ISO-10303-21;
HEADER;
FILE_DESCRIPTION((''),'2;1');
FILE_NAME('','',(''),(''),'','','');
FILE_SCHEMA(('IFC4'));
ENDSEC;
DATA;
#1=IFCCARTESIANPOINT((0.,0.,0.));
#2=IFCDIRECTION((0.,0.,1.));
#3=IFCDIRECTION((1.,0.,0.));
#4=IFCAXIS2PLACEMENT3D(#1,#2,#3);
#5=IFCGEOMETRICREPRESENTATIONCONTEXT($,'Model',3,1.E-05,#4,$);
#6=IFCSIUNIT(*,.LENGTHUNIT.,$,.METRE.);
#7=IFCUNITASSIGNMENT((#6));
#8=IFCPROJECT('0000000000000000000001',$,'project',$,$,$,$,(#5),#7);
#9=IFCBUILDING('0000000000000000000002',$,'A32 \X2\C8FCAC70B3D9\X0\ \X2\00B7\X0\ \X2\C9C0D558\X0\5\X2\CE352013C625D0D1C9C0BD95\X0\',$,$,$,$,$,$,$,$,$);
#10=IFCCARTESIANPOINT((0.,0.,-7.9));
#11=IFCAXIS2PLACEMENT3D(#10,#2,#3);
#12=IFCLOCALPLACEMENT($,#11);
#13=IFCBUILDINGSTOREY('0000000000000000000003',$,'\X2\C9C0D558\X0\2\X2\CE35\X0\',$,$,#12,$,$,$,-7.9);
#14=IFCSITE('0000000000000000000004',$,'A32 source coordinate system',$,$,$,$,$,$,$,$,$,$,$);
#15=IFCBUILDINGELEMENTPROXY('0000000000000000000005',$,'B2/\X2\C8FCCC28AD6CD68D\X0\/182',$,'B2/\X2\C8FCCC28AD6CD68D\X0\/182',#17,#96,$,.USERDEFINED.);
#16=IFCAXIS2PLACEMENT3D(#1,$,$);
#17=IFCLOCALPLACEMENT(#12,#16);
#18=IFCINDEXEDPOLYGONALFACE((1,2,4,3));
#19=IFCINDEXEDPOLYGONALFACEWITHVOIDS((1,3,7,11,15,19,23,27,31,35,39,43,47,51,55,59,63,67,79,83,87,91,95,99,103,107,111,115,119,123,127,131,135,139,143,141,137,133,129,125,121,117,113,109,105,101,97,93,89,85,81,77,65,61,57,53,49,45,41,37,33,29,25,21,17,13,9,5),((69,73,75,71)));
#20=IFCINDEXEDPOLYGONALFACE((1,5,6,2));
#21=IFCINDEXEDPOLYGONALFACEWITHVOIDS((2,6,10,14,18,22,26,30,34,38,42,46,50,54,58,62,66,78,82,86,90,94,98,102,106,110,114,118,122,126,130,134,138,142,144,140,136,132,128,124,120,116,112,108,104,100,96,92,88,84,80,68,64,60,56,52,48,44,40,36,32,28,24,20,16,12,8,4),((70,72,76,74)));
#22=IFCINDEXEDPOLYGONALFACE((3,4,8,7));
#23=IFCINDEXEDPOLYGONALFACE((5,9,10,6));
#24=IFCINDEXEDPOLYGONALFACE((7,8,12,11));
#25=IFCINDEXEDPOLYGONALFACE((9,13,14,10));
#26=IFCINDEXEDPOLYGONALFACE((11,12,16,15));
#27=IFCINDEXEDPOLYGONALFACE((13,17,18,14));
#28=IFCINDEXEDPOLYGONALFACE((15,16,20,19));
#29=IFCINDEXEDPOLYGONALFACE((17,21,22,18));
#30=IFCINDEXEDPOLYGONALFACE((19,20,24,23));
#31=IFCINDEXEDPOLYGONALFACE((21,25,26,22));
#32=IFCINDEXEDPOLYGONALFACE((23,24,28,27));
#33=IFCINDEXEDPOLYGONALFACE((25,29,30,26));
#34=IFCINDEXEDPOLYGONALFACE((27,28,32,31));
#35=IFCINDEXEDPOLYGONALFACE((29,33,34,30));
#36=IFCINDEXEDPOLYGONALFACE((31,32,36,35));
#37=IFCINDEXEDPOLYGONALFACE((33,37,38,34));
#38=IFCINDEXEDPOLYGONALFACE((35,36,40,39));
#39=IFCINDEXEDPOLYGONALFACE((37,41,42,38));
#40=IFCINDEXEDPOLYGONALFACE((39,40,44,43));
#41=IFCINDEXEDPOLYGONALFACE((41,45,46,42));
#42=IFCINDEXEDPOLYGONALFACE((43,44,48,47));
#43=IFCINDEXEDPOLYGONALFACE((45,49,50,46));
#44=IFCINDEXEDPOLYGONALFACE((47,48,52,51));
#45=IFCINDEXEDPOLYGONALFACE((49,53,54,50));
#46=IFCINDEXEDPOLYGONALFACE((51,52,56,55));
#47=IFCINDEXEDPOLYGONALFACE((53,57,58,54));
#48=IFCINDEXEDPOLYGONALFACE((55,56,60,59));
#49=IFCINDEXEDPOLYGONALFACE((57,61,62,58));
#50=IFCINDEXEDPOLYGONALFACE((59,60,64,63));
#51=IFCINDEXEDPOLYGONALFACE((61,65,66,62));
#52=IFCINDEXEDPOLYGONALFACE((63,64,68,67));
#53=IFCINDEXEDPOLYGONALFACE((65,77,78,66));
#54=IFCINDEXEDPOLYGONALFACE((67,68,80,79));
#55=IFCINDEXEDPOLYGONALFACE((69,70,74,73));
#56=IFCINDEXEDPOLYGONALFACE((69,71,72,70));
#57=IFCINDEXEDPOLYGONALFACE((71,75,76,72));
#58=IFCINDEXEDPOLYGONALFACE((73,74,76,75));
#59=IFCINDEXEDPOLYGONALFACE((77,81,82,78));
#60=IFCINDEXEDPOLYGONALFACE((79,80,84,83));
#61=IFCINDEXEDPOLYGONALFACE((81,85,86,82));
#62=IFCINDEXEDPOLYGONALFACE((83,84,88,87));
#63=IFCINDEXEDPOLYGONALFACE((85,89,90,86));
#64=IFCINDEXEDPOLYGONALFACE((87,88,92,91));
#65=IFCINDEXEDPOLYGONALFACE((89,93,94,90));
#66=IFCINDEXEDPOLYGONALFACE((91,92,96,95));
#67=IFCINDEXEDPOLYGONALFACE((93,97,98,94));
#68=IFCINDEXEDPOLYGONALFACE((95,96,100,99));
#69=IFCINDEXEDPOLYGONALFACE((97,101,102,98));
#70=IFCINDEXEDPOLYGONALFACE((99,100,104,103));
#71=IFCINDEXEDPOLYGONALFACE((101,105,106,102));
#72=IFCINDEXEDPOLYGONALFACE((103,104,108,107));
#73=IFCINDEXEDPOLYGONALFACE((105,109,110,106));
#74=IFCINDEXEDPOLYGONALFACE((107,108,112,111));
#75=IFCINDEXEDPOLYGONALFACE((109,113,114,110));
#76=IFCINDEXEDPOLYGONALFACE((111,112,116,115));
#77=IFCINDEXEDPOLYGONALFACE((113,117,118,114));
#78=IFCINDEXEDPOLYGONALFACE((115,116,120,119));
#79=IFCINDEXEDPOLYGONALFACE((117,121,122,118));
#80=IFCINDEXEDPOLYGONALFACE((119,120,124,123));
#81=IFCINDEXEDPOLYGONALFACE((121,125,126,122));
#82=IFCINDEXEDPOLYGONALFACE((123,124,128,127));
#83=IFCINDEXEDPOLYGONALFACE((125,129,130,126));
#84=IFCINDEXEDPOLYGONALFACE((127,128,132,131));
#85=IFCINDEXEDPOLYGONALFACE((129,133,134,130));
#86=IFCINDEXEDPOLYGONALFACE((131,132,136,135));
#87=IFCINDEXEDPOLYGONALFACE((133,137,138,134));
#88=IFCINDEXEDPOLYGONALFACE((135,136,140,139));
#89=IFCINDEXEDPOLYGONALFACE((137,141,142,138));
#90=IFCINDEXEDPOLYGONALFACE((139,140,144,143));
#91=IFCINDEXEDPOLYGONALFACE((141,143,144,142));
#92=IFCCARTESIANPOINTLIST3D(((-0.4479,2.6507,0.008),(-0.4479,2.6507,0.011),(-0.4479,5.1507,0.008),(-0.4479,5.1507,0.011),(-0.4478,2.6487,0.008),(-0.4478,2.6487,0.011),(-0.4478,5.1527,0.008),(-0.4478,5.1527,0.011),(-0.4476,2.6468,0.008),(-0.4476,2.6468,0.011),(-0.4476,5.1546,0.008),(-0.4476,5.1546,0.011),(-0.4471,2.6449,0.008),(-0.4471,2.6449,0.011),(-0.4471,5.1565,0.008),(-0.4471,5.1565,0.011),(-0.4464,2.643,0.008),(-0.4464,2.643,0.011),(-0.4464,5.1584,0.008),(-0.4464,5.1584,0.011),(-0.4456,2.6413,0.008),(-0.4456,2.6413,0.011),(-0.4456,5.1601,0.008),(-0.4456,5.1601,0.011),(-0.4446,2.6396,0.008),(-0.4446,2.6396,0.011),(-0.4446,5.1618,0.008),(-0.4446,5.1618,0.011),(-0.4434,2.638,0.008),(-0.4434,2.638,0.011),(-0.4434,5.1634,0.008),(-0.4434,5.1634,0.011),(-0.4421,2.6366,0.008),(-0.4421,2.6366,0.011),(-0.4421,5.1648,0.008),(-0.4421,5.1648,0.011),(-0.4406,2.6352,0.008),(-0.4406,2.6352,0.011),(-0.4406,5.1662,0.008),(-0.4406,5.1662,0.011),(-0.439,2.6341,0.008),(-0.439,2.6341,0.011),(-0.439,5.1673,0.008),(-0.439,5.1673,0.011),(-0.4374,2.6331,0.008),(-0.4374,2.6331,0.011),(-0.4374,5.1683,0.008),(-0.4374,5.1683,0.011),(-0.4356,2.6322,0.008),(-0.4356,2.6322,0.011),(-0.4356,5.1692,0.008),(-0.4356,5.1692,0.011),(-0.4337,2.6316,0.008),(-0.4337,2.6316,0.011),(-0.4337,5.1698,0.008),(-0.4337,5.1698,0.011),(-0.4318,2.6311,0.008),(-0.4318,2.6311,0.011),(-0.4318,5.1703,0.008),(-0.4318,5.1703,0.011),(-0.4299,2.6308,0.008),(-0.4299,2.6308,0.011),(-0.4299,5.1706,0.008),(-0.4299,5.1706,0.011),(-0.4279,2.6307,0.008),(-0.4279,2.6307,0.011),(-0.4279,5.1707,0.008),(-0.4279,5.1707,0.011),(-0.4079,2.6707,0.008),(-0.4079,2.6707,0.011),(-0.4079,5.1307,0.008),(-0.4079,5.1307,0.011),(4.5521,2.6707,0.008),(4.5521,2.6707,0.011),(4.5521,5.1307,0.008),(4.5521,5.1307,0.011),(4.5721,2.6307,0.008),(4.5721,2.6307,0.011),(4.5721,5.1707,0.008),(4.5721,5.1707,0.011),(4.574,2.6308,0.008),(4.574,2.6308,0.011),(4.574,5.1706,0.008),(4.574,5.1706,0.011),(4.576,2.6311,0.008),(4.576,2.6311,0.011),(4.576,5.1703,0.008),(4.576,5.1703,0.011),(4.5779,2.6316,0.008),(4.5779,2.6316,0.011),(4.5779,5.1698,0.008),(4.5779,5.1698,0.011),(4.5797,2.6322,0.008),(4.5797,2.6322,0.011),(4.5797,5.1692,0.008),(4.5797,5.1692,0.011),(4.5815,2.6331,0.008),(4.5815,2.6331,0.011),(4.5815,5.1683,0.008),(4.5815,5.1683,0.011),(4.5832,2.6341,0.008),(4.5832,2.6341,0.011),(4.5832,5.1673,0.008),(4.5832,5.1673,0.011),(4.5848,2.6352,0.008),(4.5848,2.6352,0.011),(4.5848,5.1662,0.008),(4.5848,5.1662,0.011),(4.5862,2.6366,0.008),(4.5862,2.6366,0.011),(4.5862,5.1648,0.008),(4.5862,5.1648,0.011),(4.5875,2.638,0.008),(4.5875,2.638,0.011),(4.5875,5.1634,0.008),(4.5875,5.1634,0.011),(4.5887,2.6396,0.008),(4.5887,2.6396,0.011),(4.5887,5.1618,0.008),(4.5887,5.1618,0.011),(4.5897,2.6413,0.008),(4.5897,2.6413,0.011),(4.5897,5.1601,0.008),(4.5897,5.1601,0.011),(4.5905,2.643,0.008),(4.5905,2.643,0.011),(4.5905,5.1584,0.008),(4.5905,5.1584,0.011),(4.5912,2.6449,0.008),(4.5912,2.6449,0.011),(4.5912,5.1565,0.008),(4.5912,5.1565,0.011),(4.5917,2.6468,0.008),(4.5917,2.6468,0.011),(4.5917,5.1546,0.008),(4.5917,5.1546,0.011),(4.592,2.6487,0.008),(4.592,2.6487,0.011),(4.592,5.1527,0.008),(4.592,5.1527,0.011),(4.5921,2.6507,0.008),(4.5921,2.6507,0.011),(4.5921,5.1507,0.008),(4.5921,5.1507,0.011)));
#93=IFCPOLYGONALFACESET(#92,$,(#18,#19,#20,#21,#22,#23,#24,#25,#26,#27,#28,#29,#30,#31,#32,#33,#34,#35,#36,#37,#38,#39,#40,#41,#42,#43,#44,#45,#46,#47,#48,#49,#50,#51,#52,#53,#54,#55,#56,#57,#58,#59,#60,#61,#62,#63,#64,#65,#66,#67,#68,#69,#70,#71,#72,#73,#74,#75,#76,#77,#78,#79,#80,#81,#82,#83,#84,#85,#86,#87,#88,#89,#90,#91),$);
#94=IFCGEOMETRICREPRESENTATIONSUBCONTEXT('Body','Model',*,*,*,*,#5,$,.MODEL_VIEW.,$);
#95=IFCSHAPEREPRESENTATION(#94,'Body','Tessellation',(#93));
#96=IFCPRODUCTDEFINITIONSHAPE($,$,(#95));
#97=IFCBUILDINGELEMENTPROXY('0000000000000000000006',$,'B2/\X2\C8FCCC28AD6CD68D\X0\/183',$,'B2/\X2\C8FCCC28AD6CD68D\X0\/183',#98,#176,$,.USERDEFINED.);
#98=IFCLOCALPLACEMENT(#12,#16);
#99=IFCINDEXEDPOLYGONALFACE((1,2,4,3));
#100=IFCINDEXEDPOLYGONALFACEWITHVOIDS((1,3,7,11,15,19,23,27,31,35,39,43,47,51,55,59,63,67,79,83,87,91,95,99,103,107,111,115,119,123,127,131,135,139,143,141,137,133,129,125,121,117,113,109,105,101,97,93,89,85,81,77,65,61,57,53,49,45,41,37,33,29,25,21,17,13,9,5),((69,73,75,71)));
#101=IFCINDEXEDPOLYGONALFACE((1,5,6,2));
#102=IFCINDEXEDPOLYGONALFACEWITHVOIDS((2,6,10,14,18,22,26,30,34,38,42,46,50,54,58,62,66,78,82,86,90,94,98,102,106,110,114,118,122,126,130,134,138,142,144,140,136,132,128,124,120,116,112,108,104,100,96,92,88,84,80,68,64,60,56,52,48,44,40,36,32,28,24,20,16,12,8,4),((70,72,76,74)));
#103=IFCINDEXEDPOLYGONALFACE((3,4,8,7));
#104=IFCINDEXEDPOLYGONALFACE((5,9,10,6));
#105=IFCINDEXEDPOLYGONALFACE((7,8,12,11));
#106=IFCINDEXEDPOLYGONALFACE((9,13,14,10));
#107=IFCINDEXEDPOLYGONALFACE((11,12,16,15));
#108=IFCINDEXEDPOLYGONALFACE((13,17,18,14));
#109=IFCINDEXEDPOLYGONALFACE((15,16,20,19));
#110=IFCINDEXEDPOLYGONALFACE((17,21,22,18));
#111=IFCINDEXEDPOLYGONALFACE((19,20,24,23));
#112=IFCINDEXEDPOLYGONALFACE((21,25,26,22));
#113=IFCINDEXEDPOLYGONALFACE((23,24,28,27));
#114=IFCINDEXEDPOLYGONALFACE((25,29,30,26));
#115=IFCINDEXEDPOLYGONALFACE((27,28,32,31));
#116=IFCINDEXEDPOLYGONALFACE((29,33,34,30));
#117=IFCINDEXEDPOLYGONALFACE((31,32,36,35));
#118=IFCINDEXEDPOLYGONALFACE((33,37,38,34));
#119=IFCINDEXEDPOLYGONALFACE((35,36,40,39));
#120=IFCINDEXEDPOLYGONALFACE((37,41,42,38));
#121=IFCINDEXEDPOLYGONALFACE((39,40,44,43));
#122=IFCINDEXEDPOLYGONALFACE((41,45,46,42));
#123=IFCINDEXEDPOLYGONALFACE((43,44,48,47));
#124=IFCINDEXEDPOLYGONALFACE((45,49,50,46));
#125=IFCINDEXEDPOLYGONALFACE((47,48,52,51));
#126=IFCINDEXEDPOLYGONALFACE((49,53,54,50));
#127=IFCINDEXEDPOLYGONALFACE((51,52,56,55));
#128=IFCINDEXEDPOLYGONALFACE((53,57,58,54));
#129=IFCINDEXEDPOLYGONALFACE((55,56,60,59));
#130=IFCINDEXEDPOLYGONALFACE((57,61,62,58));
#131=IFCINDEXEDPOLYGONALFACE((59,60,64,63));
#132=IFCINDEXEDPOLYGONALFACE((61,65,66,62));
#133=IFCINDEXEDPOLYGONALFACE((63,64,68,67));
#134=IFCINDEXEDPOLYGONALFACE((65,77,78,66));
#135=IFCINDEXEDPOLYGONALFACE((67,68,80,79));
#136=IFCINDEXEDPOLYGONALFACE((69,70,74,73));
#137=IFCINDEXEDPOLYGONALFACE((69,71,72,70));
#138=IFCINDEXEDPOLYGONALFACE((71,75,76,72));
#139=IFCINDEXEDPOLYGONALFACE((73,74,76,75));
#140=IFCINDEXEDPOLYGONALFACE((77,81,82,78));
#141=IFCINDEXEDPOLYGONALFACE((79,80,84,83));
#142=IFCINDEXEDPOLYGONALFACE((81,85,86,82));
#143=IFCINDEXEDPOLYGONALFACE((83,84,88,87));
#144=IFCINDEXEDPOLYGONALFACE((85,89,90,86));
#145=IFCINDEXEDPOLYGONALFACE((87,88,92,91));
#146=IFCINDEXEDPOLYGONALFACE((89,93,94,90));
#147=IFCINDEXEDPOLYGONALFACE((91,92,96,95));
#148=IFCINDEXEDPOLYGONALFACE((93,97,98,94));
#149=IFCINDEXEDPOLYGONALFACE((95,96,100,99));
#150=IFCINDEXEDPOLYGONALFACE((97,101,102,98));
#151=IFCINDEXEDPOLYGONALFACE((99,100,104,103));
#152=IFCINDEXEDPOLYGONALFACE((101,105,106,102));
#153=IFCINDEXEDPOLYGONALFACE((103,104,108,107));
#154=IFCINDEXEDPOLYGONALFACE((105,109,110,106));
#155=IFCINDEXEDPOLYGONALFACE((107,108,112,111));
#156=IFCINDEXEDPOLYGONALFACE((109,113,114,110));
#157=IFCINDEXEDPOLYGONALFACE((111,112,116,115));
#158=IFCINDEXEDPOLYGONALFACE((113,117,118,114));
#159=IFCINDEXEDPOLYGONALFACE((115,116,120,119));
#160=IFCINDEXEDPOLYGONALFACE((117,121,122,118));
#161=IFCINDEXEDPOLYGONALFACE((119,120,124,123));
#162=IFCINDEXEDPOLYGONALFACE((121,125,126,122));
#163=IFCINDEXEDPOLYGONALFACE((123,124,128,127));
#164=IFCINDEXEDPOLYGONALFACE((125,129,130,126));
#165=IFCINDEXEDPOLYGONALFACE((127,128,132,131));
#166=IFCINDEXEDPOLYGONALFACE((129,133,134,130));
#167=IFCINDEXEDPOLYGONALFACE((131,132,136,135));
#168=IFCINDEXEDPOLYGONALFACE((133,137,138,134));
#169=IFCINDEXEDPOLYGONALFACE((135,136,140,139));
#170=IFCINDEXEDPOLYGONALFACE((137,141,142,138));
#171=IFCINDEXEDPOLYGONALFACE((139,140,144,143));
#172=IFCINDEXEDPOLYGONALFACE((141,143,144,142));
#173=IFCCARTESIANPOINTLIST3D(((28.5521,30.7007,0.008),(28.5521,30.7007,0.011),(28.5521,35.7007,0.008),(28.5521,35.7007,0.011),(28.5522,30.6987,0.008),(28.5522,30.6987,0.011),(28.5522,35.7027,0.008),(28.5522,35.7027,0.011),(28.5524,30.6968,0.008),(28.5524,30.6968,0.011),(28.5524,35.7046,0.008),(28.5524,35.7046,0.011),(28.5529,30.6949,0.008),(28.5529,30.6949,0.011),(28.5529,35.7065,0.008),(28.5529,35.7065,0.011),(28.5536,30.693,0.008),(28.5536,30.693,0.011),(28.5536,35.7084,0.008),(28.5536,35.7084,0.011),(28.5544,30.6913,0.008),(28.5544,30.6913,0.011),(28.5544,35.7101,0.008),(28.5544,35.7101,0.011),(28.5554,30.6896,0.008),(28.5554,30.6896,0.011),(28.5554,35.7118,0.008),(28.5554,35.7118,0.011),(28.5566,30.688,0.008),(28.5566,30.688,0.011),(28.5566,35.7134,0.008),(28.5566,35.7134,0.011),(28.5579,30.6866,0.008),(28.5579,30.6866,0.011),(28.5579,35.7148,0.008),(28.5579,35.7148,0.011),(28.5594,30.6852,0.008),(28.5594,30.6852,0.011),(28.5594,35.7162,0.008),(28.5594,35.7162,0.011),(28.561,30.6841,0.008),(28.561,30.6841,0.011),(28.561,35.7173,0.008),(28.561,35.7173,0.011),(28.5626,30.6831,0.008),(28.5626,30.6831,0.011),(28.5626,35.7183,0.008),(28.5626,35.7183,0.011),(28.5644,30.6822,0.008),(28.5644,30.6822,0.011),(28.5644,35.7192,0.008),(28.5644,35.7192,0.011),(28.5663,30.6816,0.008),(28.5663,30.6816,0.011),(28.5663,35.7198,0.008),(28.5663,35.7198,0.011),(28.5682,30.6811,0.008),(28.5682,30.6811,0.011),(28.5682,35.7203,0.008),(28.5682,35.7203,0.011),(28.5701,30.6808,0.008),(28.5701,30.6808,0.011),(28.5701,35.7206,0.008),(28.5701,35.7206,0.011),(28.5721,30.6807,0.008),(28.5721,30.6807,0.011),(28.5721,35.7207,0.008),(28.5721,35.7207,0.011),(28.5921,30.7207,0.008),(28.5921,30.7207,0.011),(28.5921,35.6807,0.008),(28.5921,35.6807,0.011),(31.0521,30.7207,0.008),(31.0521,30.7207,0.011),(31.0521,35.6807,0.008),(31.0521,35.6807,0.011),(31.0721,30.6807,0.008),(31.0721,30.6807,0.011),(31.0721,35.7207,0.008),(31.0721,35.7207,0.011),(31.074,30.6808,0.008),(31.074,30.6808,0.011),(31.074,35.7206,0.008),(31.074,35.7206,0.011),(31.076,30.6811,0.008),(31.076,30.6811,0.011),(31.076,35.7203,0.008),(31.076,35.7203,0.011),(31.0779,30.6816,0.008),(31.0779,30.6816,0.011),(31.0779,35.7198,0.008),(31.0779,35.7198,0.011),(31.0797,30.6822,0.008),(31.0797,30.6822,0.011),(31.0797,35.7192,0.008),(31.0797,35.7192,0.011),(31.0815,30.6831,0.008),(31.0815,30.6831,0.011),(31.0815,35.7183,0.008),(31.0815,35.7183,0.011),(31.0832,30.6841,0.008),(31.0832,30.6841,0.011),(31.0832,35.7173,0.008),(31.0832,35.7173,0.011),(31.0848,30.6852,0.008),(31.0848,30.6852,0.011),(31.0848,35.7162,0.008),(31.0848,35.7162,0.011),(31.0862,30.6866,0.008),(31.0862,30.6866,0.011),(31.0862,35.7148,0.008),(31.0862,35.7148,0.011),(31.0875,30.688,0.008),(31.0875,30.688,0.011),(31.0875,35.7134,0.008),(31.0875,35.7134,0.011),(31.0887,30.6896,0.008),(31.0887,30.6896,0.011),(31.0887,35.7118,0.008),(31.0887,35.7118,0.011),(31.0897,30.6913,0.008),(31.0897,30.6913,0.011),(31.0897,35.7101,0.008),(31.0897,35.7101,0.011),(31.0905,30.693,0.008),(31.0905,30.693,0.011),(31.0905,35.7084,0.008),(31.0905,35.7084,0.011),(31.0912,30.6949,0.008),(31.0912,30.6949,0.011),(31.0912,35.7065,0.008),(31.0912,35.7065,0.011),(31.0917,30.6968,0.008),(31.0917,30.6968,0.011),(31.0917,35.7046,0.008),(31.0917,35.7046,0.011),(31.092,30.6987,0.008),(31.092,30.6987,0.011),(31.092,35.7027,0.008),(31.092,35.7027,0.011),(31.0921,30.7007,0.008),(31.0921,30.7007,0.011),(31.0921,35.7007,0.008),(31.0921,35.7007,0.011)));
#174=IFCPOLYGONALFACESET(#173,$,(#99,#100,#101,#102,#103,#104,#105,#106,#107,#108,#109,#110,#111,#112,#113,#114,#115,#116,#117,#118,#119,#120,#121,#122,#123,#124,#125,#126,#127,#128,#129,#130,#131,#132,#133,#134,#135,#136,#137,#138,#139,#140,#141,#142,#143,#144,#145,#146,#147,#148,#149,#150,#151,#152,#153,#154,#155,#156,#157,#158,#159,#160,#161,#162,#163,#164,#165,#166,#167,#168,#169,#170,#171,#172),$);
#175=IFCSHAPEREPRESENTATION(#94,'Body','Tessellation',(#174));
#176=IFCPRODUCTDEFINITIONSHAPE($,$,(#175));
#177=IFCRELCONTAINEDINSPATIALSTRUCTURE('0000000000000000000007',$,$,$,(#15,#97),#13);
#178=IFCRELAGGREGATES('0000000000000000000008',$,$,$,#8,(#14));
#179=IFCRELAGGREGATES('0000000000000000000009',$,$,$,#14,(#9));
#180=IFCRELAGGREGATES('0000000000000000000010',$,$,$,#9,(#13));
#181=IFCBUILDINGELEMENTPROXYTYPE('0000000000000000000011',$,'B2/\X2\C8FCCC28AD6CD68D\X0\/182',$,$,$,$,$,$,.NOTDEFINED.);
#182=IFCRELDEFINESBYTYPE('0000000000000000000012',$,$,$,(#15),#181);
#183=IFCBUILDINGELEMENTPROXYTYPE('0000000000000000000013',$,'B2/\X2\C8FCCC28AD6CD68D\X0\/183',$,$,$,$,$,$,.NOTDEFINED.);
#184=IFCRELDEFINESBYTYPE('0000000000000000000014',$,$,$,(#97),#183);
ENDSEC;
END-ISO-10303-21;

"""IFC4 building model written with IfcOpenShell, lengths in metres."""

from ifc_helpers import new_model, si_unit, frame, origin, origin_with_axes, place, context, subcontext, project, spatial, polyline, outline, extrude, source, transform, mapped, type_object, type_shapes, element, save


model = new_model("IFC4")

# Units and contexts
model_context = context("Model", 3, precision=1e-05, world=origin_with_axes())
body_context = subcontext(model_context, "Body", "Model", "MODEL_VIEW")
ifc_project = project(units=[si_unit("LENGTHUNIT", "METRE")], contexts=[model_context])

# Site, building, storey
site = spatial("IfcSite", under=ifc_project, Name="A32 source coordinate system")
building = spatial("IfcBuilding", under=site, Name="A32 주거동 · 지하5층–옥탑지붕")
storey_placement = place(None, frame((0.0, 0.0, -7.9), z_axis=(0.0, 0.0, 1.0), x_axis=(1.0, 0.0, 0.0)))
storey = spatial("IfcBuildingStorey", under=building, at=storey_placement, Name="지하2층", Elevation=-7.9)

# Building element proxies
building_element_proxy_type_1 = type_object("IfcBuildingElementProxyType", Name="B2/주차구획/182", PredefinedType="NOTDEFINED")
shared_shape_1 = source(origin(), body_context, "Body", "SweptSolid", [
    extrude(outline(polyline([(-0.4279, 2.6307), (-0.4299, 2.6308), (-0.4318, 2.6311), (-0.4337, 2.6316), (-0.4356, 2.6322), (-0.4374, 2.6331), (-0.439, 2.6341), (-0.4406, 2.6352), (-0.4421, 2.6366), (-0.4434, 2.638), (-0.4446, 2.6396), (-0.4456, 2.6413), (-0.4464, 2.643), (-0.4471, 2.6449), (-0.4476, 2.6468), (-0.4478, 2.6487), (-0.4479, 2.6507), (-0.4479, 5.1507), (-0.4478, 5.1527), (-0.4476, 5.1546), (-0.4471, 5.1565), (-0.4464, 5.1584), (-0.4456, 5.1601), (-0.4446, 5.1618), (-0.4434, 5.1634), (-0.4421, 5.1648), (-0.4406, 5.1662), (-0.439, 5.1673), (-0.4374, 5.1683), (-0.4356, 5.1692), (-0.4337, 5.1698), (-0.4318, 5.1703), (-0.4299, 5.1706), (-0.4279, 5.1707), (4.5721, 5.1707), (4.574, 5.1706), (4.576, 5.1703), (4.5779, 5.1698), (4.5797, 5.1692), (4.5815, 5.1683), (4.5832, 5.1673), (4.5848, 5.1662), (4.5862, 5.1648), (4.5875, 5.1634), (4.5887, 5.1618), (4.5897, 5.1601), (4.5905, 5.1584), (4.5912, 5.1565), (4.5917, 5.1546), (4.592, 5.1527), (4.5921, 5.1507), (4.5921, 2.6507), (4.592, 2.6487), (4.5917, 2.6468), (4.5912, 2.6449), (4.5905, 2.643), (4.5897, 2.6413), (4.5887, 2.6396), (4.5875, 2.638), (4.5862, 2.6366), (4.5848, 2.6352), (4.5832, 2.6341), (4.5815, 2.6331), (4.5797, 2.6322), (4.5779, 2.6316), (4.576, 2.6311), (4.574, 2.6308), (4.5721, 2.6307), (-0.4279, 2.6307)]), holes=[polyline([(-0.4079, 2.6707), (4.5521, 2.6707), (4.5521, 5.1307), (-0.4079, 5.1307), (-0.4079, 2.6707)])]), frame((0.0, 0.0, 0.008)), (0.0, 0.0, 1.0), 0.003),
])
type_shapes(building_element_proxy_type_1, [shared_shape_1])
proxy_1_placement = place(storey_placement, origin_with_axes())
element("IfcBuildingElementProxy", 1, at=proxy_1_placement, inside=storey, type_object=building_element_proxy_type_1, Name="B2/주차구획/182", ObjectType="B2/주차구획/182", PredefinedType="USERDEFINED", context=body_context, shape_type="MappedRepresentation", body=[
    mapped(shared_shape_1, transform((0.0, 0.0, 0.0), scale=1.0)),
])
building_element_proxy_type_2 = type_object("IfcBuildingElementProxyType", Name="B2/주차구획/183", PredefinedType="NOTDEFINED")
shared_shape_2 = source(origin(), body_context, "Body", "SweptSolid", [
    extrude(outline(polyline([(28.5521, 35.7007), (28.5522, 35.7027), (28.5524, 35.7046), (28.5529, 35.7065), (28.5536, 35.7084), (28.5544, 35.7101), (28.5554, 35.7118), (28.5566, 35.7134), (28.5579, 35.7148), (28.5594, 35.7162), (28.561, 35.7173), (28.5626, 35.7183), (28.5644, 35.7192), (28.5663, 35.7198), (28.5682, 35.7203), (28.5701, 35.7206), (28.5721, 35.7207), (31.0721, 35.7207), (31.074, 35.7206), (31.076, 35.7203), (31.0779, 35.7198), (31.0797, 35.7192), (31.0815, 35.7183), (31.0832, 35.7173), (31.0848, 35.7162), (31.0862, 35.7148), (31.0875, 35.7134), (31.0887, 35.7118), (31.0897, 35.7101), (31.0905, 35.7084), (31.0912, 35.7065), (31.0917, 35.7046), (31.092, 35.7027), (31.0921, 35.7007), (31.0921, 30.7007), (31.092, 30.6987), (31.0917, 30.6968), (31.0912, 30.6949), (31.0905, 30.693), (31.0897, 30.6913), (31.0887, 30.6896), (31.0875, 30.688), (31.0862, 30.6866), (31.0848, 30.6852), (31.0832, 30.6841), (31.0815, 30.6831), (31.0797, 30.6822), (31.0779, 30.6816), (31.076, 30.6811), (31.074, 30.6808), (31.0721, 30.6807), (28.5721, 30.6807), (28.5701, 30.6808), (28.5682, 30.6811), (28.5663, 30.6816), (28.5644, 30.6822), (28.5626, 30.6831), (28.561, 30.6841), (28.5594, 30.6852), (28.5579, 30.6866), (28.5566, 30.688), (28.5554, 30.6896), (28.5544, 30.6913), (28.5536, 30.693), (28.5529, 30.6949), (28.5524, 30.6968), (28.5522, 30.6987), (28.5521, 30.7007), (28.5521, 35.7007)]), holes=[polyline([(28.5921, 35.6807), (28.5921, 30.7207), (31.0521, 30.7207), (31.0521, 35.6807), (28.5921, 35.6807)])]), frame((0.0, 0.0, 0.008)), (0.0, 0.0, 1.0), 0.003),
])
type_shapes(building_element_proxy_type_2, [shared_shape_2])
proxy_2_placement = place(storey_placement, origin_with_axes())
element("IfcBuildingElementProxy", 2, at=proxy_2_placement, inside=storey, type_object=building_element_proxy_type_2, Name="B2/주차구획/183", ObjectType="B2/주차구획/183", PredefinedType="USERDEFINED", context=body_context, shape_type="MappedRepresentation", body=[
    mapped(shared_shape_2, transform((0.0, 0.0, 0.0), scale=1.0)),
])

save(model, "model.ifc")
